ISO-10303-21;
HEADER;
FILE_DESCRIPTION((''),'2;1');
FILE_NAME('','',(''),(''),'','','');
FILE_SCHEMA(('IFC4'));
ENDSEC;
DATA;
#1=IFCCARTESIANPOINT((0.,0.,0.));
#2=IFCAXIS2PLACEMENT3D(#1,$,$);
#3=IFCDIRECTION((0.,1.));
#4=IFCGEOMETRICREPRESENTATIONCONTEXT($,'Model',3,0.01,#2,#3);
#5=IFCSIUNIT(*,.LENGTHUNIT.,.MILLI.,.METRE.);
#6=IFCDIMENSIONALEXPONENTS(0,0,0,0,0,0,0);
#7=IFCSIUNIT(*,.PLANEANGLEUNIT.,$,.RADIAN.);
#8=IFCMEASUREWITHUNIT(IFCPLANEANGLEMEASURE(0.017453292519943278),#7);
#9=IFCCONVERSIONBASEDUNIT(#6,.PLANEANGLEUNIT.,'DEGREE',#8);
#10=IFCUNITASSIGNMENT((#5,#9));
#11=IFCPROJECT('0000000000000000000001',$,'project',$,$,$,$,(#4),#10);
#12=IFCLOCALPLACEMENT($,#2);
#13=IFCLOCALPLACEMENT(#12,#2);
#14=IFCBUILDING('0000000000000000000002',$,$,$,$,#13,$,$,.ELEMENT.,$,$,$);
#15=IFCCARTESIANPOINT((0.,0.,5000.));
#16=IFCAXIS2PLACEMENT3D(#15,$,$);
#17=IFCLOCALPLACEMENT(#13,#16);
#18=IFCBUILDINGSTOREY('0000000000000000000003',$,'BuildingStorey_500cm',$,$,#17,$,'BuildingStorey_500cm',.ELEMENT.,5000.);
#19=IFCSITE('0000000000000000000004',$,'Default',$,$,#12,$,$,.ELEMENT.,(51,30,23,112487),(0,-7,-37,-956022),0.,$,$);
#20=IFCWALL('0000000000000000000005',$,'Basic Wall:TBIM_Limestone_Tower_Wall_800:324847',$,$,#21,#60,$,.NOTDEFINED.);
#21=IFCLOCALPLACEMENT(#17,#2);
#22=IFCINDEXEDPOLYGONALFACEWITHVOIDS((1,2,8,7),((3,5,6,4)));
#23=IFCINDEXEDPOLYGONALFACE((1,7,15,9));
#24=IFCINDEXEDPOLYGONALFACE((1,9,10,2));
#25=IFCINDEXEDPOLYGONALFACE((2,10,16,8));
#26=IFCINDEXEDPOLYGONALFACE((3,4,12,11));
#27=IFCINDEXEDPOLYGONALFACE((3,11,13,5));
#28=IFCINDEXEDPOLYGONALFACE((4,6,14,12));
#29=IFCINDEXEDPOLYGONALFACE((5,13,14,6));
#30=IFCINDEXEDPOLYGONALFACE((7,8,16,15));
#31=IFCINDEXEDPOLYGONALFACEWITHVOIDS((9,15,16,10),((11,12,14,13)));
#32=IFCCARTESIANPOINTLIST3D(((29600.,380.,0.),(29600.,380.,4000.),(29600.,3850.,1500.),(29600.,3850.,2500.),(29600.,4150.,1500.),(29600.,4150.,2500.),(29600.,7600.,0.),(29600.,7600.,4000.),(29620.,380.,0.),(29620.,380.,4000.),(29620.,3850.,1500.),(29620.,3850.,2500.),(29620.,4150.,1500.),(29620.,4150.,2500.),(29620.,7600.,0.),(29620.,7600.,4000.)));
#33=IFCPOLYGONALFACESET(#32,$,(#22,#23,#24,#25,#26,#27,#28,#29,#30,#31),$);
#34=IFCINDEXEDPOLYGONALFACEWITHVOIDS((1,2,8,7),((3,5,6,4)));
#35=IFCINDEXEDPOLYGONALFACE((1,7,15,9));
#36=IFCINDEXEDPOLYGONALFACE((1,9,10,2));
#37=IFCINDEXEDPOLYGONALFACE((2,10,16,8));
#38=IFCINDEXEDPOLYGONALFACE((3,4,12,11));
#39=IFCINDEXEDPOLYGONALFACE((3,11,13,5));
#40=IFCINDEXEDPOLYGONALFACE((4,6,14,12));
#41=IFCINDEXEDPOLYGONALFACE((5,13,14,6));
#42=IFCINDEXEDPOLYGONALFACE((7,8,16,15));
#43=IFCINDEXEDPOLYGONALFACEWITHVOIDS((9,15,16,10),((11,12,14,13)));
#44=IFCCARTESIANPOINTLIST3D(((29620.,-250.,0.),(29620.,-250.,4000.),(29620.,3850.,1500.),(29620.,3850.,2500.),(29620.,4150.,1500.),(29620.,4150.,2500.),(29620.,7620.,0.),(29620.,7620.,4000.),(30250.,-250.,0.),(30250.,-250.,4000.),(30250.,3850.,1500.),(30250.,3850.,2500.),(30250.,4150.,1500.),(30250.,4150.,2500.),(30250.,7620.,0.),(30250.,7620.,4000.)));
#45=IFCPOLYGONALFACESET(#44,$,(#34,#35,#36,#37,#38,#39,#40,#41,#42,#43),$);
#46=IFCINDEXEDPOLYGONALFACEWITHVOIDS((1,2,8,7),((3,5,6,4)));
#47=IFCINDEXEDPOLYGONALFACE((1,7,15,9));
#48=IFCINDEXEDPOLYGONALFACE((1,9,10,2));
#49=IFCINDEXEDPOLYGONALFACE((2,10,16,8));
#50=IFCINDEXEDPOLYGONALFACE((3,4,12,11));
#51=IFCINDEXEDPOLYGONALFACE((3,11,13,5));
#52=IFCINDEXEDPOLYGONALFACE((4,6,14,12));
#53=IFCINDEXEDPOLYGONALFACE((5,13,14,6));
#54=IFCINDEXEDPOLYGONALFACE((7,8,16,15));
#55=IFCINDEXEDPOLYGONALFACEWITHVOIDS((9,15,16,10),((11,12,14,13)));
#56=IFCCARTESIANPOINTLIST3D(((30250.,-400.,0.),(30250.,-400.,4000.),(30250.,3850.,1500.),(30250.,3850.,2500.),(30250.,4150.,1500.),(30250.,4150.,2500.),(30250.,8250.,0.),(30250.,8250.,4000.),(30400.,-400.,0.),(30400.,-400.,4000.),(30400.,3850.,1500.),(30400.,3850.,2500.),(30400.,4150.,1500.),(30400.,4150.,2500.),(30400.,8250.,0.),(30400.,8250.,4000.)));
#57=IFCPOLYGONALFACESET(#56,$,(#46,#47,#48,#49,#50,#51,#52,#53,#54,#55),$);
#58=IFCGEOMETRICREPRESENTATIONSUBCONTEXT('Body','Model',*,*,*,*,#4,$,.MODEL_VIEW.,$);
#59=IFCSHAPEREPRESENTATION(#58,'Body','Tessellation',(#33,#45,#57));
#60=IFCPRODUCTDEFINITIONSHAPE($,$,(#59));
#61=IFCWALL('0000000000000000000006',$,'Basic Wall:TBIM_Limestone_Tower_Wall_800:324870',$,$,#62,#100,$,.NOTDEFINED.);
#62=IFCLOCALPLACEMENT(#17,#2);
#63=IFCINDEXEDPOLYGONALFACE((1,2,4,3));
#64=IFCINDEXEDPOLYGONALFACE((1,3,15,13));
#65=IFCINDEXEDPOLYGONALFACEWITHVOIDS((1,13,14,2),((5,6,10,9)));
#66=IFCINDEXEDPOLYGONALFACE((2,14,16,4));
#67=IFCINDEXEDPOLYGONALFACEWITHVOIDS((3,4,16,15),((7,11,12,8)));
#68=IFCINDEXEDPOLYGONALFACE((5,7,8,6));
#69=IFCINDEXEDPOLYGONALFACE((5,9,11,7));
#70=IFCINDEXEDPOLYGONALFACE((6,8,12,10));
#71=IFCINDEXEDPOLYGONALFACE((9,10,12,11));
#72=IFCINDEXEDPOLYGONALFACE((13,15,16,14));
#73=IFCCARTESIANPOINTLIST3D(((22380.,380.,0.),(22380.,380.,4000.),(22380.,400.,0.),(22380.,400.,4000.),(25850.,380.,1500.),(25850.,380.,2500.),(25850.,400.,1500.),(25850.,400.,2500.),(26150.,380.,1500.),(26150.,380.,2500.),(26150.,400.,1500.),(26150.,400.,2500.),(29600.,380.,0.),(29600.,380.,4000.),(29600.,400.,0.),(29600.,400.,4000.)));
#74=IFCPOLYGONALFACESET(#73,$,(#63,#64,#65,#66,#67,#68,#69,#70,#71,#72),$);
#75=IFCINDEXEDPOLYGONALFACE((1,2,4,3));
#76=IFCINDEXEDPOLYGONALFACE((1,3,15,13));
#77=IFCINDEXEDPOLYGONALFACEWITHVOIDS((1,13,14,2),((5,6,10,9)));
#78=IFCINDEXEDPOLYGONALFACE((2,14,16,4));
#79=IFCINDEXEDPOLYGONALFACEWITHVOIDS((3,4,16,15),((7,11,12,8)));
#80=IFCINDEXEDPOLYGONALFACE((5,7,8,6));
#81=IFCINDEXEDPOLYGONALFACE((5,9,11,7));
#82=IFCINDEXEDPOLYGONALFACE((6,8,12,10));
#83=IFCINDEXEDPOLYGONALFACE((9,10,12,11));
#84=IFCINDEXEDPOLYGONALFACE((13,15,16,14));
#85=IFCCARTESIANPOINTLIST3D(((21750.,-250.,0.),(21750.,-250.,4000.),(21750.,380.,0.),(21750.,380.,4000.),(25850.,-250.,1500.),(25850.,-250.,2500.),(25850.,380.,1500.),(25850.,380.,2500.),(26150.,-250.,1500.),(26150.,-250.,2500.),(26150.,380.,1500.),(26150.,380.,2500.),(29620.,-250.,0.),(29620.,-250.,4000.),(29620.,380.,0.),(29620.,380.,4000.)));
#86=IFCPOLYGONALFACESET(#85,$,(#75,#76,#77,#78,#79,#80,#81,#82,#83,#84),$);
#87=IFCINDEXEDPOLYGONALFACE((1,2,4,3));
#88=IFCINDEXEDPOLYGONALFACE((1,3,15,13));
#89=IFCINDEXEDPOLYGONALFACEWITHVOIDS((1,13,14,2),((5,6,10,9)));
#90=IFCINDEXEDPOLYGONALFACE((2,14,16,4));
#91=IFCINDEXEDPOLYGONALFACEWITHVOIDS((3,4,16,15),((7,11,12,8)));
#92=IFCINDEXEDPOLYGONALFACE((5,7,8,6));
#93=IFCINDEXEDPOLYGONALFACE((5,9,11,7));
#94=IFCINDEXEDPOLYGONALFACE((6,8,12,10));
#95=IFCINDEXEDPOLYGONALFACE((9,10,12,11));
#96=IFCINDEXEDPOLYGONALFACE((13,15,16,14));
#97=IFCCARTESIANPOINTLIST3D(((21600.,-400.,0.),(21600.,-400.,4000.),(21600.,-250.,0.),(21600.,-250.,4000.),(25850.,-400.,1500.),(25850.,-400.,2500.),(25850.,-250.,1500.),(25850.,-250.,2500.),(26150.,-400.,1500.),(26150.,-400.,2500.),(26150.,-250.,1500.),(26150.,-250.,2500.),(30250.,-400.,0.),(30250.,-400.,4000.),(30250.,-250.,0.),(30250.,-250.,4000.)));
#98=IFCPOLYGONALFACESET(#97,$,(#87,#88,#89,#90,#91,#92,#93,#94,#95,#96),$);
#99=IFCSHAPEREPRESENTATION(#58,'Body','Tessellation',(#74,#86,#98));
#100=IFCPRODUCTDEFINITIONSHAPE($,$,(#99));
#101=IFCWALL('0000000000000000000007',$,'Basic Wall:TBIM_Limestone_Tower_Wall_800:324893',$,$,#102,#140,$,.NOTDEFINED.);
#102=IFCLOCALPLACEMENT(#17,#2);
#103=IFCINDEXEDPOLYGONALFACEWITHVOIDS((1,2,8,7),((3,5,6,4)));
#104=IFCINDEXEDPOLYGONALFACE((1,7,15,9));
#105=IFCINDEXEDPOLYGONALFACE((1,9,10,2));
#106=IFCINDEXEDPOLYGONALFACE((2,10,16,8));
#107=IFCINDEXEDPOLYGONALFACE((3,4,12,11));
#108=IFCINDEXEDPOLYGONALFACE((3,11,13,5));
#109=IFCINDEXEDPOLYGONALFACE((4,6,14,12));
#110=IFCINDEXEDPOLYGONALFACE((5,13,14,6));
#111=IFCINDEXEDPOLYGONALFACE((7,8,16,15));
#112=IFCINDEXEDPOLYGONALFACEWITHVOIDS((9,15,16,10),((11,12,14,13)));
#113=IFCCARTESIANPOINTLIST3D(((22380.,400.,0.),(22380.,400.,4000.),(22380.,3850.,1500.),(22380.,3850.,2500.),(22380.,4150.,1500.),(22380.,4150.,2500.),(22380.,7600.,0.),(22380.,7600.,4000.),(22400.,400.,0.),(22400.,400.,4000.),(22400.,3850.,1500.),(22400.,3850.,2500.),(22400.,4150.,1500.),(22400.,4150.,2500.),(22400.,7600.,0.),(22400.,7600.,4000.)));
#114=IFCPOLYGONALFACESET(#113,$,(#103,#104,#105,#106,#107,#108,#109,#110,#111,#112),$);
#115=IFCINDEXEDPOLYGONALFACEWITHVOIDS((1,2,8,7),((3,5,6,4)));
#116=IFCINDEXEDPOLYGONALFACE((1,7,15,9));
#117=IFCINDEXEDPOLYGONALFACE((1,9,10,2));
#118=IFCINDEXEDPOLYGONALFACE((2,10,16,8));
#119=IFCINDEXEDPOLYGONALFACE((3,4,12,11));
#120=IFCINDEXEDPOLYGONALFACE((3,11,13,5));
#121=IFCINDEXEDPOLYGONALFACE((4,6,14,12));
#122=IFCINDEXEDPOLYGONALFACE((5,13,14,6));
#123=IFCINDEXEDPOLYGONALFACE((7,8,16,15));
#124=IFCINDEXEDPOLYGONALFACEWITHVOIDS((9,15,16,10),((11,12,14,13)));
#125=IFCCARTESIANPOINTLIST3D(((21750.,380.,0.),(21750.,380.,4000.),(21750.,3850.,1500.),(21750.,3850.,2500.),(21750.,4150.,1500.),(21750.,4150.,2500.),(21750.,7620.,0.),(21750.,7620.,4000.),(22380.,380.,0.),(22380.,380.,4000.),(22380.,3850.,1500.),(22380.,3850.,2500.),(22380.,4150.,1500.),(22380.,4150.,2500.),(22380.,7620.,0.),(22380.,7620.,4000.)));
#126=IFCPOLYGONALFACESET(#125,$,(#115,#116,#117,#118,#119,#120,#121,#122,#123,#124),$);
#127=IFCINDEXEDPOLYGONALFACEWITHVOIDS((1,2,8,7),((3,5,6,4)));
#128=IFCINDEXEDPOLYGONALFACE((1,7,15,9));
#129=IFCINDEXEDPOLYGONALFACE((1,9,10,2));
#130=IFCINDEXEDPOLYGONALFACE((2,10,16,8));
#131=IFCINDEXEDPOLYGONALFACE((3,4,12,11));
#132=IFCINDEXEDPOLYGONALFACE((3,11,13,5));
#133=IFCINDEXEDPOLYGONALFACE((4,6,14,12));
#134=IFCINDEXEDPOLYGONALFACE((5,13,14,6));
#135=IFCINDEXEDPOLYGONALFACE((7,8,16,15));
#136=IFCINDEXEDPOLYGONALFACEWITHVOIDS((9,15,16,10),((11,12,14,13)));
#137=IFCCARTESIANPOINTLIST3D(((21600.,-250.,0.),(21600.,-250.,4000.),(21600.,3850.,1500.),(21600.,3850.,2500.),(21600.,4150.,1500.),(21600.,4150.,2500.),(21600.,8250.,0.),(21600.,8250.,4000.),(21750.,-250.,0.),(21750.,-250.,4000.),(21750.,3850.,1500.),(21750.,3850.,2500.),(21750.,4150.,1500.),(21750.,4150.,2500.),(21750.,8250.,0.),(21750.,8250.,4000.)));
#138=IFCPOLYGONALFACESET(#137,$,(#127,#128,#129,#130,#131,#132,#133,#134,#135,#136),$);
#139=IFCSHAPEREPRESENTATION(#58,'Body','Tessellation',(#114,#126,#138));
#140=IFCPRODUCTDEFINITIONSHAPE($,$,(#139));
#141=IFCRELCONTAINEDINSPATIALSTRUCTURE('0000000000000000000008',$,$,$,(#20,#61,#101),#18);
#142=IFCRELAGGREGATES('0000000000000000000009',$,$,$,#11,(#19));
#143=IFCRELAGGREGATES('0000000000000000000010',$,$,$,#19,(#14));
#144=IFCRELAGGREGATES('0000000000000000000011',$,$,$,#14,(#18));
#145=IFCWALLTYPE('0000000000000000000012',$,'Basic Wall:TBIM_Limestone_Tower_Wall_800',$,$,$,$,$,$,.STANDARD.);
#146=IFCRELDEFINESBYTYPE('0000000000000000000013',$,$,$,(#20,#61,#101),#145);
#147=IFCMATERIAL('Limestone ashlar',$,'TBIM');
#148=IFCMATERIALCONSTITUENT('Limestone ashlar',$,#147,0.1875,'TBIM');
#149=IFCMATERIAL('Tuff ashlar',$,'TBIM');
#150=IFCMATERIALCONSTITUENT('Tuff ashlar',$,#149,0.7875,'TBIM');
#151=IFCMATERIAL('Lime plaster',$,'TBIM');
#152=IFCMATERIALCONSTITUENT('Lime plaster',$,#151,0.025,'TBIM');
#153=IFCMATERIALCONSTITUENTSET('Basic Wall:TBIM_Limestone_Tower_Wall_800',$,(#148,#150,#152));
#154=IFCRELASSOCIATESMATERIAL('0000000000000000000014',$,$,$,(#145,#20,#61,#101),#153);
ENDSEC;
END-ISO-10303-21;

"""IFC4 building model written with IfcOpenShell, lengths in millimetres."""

from ifc_helpers import new_model, entity, si_unit, converted_unit, direction, frame, origin, place, context, subcontext, project, spatial, indexed_curve, outline, extrude, material, constituent, constituent_set, type_object, element, save


model = new_model("IFC4")

# Units and contexts
model_context = context("Model", 3, precision=0.01, world=origin(), true_north=direction((0.0, 1.0)))
body_context = subcontext(model_context, "Body", "Model", "MODEL_VIEW")
ifc_project = project(units=[si_unit("LENGTHUNIT", "METRE", prefix="MILLI"), converted_unit("PLANEANGLEUNIT", "DEGREE", entity("IfcPlaneAngleMeasure", 0.017453292519943278), si_unit("PLANEANGLEUNIT", "RADIAN"), dimensions=[0, 0, 0, 0, 0, 0, 0])], contexts=[model_context])

# Site, building, storey
site_placement = place(None, origin())
site = spatial("IfcSite", under=ifc_project, at=site_placement, Name="Default", CompositionType="ELEMENT", RefLatitude=(51, 30, 23, 112487), RefLongitude=(0, -7, -37, -956022), RefElevation=0.0)
building_placement = place(site_placement, origin())
building = spatial("IfcBuilding", under=site, at=building_placement, CompositionType="ELEMENT")
storey_placement = place(building_placement, frame((0.0, 0.0, 5000.0)))
storey = spatial("IfcBuildingStorey", under=building, at=storey_placement, Name="BuildingStorey_500cm", LongName="BuildingStorey_500cm", CompositionType="ELEMENT", Elevation=5000.0)

# Shared definitions
ifc_material_1 = material(Name="Tuff ashlar", Category="TBIM")
ifc_material_2 = material(Name="Lime plaster", Category="TBIM")

# Walls, openings
ifc_material_3 = material(Name="Limestone ashlar", Category="TBIM")
ifc_constituent_1 = constituent(ifc_material_3, Name="Limestone ashlar", Category="TBIM", fraction=0.1875)
ifc_constituent_2 = constituent(ifc_material_1, Name="Tuff ashlar", Category="TBIM", fraction=0.7875)
ifc_constituent_3 = constituent(ifc_material_2, Name="Lime plaster", Category="TBIM", fraction=0.025)
ifc_constituent_set_1 = constituent_set(constituents=[ifc_constituent_1, ifc_constituent_2, ifc_constituent_3], Name="Basic Wall:TBIM_Limestone_Tower_Wall_800")
wall_type_1 = type_object("IfcWallType", Name="Basic Wall:TBIM_Limestone_Tower_Wall_800", PredefinedType="STANDARD", material=ifc_constituent_set_1)
wall_1_placement = place(storey_placement, frame((30000.0, -400.0, 0.0), z_axis=(0.0, 0.0, 1.0), x_axis=(0.0, 1.0, 0.0)))
wall_1 = element("IfcWall", 1, at=wall_1_placement, inside=storey, type_object=wall_type_1, material=ifc_constituent_set_1, Name="Basic Wall:TBIM_Limestone_Tower_Wall_800:324847", PredefinedType="NOTDEFINED", context=body_context, shape_type="SweptSolid", body=[
    extrude(outline(indexed_curve([(-2413.3, -2000.0), (-2393.3, -2000.0), (4806.7, -2000.0), (4806.7, 2000.0), (-2393.3, 2000.0), (-2413.3, 2000.0), (-2413.3, -2000.0)], self_intersect=False), holes=[indexed_curve([(1056.7, 500.0), (1356.7, 500.0), (1356.7, -500.0), (1056.7, -500.0), (1056.7, 500.0)], self_intersect=False)]), frame((3193.3, 400.0, 2000.0), z_axis=(0.0, -1.0, 0.0), x_axis=(1.0, 0.0, 0.0)), (0.0, 0.0, 1.0), 20.0),
    extrude(outline(indexed_curve([(-2000.0, -3935.0), (2000.0, -3935.0), (2000.0, 3935.0), (-2000.0, 3935.0), (-2000.0, -3935.0)], self_intersect=False), holes=[indexed_curve([(500.0, -165.0), (500.0, -465.0), (-500.0, -465.0), (-500.0, -165.0), (500.0, -165.0)], self_intersect=False)]), frame((4085.0, 380.0, 2000.0), z_axis=(0.0, -1.0, 0.0), x_axis=(0.0, 0.0, 1.0)), (0.0, 0.0, 1.0), 630.0),
    extrude(outline(indexed_curve([(-2000.0, -4325.0), (2000.0, -4325.0), (2000.0, 4325.0), (-2000.0, 4325.0), (-2000.0, -4325.0)], self_intersect=False), holes=[indexed_curve([(500.0, 75.0), (500.0, -225.0), (-500.0, -225.0), (-500.0, 75.0), (500.0, 75.0)], self_intersect=False)]), frame((4325.0, -250.0, 2000.0), z_axis=(0.0, -1.0, 0.0), x_axis=(0.0, 0.0, 1.0)), (0.0, 0.0, 1.0), 150.0),
])
opening_1_placement = place(wall_1_placement, frame((4250.0, -400.0, 1500.0)))
element("IfcOpeningElement", 2, at=opening_1_placement, cuts=wall_1, PredefinedType="OPENING", context=body_context, shape_type="SweptSolid", body=[
    extrude(outline(indexed_curve([(1000.0, 0.0), (1000.0, 300.0), (0.0, 300.0), (0.0, 0.0), (1000.0, 0.0)], self_intersect=False)), frame((0.0, 0.0, 0.0), z_axis=(0.0, 1.0, 0.0), x_axis=(0.0, 0.0, 1.0)), (0.0, 0.0, 1.0), 800.0),
])
wall_2_placement = place(storey_placement, frame((21600.0, 0.0, 0.0)))
wall_2 = element("IfcWall", 3, at=wall_2_placement, inside=storey, type_object=wall_type_1, material=ifc_constituent_set_1, Name="Basic Wall:TBIM_Limestone_Tower_Wall_800:324870", PredefinedType="NOTDEFINED", context=body_context, shape_type="SweptSolid", body=[
    extrude(outline(indexed_curve([(-2000.0, -3610.0), (2000.0, -3610.0), (2000.0, 3610.0), (-2000.0, 3610.0), (-2000.0, -3610.0)], self_intersect=False), holes=[indexed_curve([(-500.0, -140.0), (-500.0, 160.0), (500.0, 160.0), (500.0, -140.0), (-500.0, -140.0)], self_intersect=False)]), frame((4390.0, 380.0, 2000.0), z_axis=(0.0, 1.0, 0.0), x_axis=(0.0, 0.0, 1.0)), (0.0, 0.0, 1.0), 20.0),
    extrude(outline(indexed_curve([(-2000.0, -3935.0), (2000.0, -3935.0), (2000.0, 3935.0), (-2000.0, 3935.0), (-2000.0, -3935.0)], self_intersect=False), holes=[indexed_curve([(-500.0, 165.0), (-500.0, 465.0), (500.0, 465.0), (500.0, 165.0), (-500.0, 165.0)], self_intersect=False)]), frame((4085.0, -250.0, 2000.0), z_axis=(0.0, 1.0, 0.0), x_axis=(0.0, 0.0, 1.0)), (0.0, 0.0, 1.0), 630.0),
    extrude(outline(indexed_curve([(-2000.0, -4325.0), (2000.0, -4325.0), (2000.0, 4325.0), (-2000.0, 4325.0), (-2000.0, -4325.0)], self_intersect=False), holes=[indexed_curve([(500.0, -75.0), (-500.0, -75.0), (-500.0, 225.0), (500.0, 225.0), (500.0, -75.0)], self_intersect=False)]), frame((4325.0, -400.0, 2000.0), z_axis=(0.0, 1.0, 0.0), x_axis=(0.0, 0.0, 1.0)), (0.0, 0.0, 1.0), 150.0),
])
opening_2_placement = place(wall_2_placement, frame((4250.0, -400.0, 1500.0)))
element("IfcOpeningElement", 4, at=opening_2_placement, cuts=wall_2, PredefinedType="OPENING", context=body_context, shape_type="SweptSolid", body=[
    extrude(outline(indexed_curve([(1000.0, 0.0), (1000.0, 300.0), (0.0, 300.0), (0.0, 0.0), (1000.0, 0.0)], self_intersect=False)), frame((0.0, 0.0, 0.0), z_axis=(0.0, 1.0, 0.0), x_axis=(0.0, 0.0, 1.0)), (0.0, 0.0, 1.0), 800.0),
])
wall_3_placement = place(storey_placement, frame((22000.0, 400.0, 0.0), z_axis=(0.0, 0.0, 1.0), x_axis=(0.0, 1.0, 0.0)))
wall_3 = element("IfcWall", 5, at=wall_3_placement, inside=storey, type_object=wall_type_1, material=ifc_constituent_set_1, Name="Basic Wall:TBIM_Limestone_Tower_Wall_800:324893", PredefinedType="NOTDEFINED", context=body_context, shape_type="SweptSolid", body=[
    extrude(outline(indexed_curve([(-2000.0, -3600.0), (2000.0, -3600.0), (2000.0, 3600.0), (-2000.0, 3600.0), (-2000.0, -3600.0)], self_intersect=False), holes=[indexed_curve([(500.0, 150.0), (500.0, -150.0), (-500.0, -150.0), (-500.0, 150.0), (500.0, 150.0)], self_intersect=False)]), frame((3600.0, -380.0, 2000.0), z_axis=(0.0, -1.0, 0.0), x_axis=(0.0, 0.0, 1.0)), (0.0, 0.0, 1.0), 20.0),
    extrude(outline(indexed_curve([(-2000.0, -3620.0), (2000.0, -3620.0), (2000.0, 3620.0), (-2000.0, 3620.0), (-2000.0, -3620.0)], self_intersect=False), holes=[indexed_curve([(500.0, 150.0), (500.0, -150.0), (-500.0, -150.0), (-500.0, 150.0), (500.0, 150.0)], self_intersect=False)]), frame((3600.0, 250.0, 2000.0), z_axis=(0.0, -1.0, 0.0), x_axis=(0.0, 0.0, 1.0)), (0.0, 0.0, 1.0), 630.0),
    extrude(outline(indexed_curve([(-4250.0, -2000.0), (4250.0, -2000.0), (4250.0, 2000.0), (-4250.0, 2000.0), (-4250.0, -2000.0)], self_intersect=False), holes=[indexed_curve([(-150.0, 500.0), (150.0, 500.0), (150.0, -500.0), (-150.0, -500.0), (-150.0, 500.0)], self_intersect=False)]), frame((3600.0, 400.0, 2000.0), z_axis=(0.0, -1.0, 0.0), x_axis=(1.0, 0.0, 0.0)), (0.0, 0.0, 1.0), 150.0),
])
opening_3_placement = place(wall_3_placement, frame((3450.0, -400.0, 1500.0)))
element("IfcOpeningElement", 6, at=opening_3_placement, cuts=wall_3, PredefinedType="OPENING", context=body_context, shape_type="SweptSolid", body=[
    extrude(outline(indexed_curve([(1000.0, 0.0), (1000.0, 300.0), (0.0, 300.0), (0.0, 0.0), (1000.0, 0.0)], self_intersect=False)), frame((0.0, 0.0, 0.0), z_axis=(0.0, 1.0, 0.0), x_axis=(0.0, 0.0, 1.0)), (0.0, 0.0, 1.0), 800.0),
])

save(model, "model.ifc")
